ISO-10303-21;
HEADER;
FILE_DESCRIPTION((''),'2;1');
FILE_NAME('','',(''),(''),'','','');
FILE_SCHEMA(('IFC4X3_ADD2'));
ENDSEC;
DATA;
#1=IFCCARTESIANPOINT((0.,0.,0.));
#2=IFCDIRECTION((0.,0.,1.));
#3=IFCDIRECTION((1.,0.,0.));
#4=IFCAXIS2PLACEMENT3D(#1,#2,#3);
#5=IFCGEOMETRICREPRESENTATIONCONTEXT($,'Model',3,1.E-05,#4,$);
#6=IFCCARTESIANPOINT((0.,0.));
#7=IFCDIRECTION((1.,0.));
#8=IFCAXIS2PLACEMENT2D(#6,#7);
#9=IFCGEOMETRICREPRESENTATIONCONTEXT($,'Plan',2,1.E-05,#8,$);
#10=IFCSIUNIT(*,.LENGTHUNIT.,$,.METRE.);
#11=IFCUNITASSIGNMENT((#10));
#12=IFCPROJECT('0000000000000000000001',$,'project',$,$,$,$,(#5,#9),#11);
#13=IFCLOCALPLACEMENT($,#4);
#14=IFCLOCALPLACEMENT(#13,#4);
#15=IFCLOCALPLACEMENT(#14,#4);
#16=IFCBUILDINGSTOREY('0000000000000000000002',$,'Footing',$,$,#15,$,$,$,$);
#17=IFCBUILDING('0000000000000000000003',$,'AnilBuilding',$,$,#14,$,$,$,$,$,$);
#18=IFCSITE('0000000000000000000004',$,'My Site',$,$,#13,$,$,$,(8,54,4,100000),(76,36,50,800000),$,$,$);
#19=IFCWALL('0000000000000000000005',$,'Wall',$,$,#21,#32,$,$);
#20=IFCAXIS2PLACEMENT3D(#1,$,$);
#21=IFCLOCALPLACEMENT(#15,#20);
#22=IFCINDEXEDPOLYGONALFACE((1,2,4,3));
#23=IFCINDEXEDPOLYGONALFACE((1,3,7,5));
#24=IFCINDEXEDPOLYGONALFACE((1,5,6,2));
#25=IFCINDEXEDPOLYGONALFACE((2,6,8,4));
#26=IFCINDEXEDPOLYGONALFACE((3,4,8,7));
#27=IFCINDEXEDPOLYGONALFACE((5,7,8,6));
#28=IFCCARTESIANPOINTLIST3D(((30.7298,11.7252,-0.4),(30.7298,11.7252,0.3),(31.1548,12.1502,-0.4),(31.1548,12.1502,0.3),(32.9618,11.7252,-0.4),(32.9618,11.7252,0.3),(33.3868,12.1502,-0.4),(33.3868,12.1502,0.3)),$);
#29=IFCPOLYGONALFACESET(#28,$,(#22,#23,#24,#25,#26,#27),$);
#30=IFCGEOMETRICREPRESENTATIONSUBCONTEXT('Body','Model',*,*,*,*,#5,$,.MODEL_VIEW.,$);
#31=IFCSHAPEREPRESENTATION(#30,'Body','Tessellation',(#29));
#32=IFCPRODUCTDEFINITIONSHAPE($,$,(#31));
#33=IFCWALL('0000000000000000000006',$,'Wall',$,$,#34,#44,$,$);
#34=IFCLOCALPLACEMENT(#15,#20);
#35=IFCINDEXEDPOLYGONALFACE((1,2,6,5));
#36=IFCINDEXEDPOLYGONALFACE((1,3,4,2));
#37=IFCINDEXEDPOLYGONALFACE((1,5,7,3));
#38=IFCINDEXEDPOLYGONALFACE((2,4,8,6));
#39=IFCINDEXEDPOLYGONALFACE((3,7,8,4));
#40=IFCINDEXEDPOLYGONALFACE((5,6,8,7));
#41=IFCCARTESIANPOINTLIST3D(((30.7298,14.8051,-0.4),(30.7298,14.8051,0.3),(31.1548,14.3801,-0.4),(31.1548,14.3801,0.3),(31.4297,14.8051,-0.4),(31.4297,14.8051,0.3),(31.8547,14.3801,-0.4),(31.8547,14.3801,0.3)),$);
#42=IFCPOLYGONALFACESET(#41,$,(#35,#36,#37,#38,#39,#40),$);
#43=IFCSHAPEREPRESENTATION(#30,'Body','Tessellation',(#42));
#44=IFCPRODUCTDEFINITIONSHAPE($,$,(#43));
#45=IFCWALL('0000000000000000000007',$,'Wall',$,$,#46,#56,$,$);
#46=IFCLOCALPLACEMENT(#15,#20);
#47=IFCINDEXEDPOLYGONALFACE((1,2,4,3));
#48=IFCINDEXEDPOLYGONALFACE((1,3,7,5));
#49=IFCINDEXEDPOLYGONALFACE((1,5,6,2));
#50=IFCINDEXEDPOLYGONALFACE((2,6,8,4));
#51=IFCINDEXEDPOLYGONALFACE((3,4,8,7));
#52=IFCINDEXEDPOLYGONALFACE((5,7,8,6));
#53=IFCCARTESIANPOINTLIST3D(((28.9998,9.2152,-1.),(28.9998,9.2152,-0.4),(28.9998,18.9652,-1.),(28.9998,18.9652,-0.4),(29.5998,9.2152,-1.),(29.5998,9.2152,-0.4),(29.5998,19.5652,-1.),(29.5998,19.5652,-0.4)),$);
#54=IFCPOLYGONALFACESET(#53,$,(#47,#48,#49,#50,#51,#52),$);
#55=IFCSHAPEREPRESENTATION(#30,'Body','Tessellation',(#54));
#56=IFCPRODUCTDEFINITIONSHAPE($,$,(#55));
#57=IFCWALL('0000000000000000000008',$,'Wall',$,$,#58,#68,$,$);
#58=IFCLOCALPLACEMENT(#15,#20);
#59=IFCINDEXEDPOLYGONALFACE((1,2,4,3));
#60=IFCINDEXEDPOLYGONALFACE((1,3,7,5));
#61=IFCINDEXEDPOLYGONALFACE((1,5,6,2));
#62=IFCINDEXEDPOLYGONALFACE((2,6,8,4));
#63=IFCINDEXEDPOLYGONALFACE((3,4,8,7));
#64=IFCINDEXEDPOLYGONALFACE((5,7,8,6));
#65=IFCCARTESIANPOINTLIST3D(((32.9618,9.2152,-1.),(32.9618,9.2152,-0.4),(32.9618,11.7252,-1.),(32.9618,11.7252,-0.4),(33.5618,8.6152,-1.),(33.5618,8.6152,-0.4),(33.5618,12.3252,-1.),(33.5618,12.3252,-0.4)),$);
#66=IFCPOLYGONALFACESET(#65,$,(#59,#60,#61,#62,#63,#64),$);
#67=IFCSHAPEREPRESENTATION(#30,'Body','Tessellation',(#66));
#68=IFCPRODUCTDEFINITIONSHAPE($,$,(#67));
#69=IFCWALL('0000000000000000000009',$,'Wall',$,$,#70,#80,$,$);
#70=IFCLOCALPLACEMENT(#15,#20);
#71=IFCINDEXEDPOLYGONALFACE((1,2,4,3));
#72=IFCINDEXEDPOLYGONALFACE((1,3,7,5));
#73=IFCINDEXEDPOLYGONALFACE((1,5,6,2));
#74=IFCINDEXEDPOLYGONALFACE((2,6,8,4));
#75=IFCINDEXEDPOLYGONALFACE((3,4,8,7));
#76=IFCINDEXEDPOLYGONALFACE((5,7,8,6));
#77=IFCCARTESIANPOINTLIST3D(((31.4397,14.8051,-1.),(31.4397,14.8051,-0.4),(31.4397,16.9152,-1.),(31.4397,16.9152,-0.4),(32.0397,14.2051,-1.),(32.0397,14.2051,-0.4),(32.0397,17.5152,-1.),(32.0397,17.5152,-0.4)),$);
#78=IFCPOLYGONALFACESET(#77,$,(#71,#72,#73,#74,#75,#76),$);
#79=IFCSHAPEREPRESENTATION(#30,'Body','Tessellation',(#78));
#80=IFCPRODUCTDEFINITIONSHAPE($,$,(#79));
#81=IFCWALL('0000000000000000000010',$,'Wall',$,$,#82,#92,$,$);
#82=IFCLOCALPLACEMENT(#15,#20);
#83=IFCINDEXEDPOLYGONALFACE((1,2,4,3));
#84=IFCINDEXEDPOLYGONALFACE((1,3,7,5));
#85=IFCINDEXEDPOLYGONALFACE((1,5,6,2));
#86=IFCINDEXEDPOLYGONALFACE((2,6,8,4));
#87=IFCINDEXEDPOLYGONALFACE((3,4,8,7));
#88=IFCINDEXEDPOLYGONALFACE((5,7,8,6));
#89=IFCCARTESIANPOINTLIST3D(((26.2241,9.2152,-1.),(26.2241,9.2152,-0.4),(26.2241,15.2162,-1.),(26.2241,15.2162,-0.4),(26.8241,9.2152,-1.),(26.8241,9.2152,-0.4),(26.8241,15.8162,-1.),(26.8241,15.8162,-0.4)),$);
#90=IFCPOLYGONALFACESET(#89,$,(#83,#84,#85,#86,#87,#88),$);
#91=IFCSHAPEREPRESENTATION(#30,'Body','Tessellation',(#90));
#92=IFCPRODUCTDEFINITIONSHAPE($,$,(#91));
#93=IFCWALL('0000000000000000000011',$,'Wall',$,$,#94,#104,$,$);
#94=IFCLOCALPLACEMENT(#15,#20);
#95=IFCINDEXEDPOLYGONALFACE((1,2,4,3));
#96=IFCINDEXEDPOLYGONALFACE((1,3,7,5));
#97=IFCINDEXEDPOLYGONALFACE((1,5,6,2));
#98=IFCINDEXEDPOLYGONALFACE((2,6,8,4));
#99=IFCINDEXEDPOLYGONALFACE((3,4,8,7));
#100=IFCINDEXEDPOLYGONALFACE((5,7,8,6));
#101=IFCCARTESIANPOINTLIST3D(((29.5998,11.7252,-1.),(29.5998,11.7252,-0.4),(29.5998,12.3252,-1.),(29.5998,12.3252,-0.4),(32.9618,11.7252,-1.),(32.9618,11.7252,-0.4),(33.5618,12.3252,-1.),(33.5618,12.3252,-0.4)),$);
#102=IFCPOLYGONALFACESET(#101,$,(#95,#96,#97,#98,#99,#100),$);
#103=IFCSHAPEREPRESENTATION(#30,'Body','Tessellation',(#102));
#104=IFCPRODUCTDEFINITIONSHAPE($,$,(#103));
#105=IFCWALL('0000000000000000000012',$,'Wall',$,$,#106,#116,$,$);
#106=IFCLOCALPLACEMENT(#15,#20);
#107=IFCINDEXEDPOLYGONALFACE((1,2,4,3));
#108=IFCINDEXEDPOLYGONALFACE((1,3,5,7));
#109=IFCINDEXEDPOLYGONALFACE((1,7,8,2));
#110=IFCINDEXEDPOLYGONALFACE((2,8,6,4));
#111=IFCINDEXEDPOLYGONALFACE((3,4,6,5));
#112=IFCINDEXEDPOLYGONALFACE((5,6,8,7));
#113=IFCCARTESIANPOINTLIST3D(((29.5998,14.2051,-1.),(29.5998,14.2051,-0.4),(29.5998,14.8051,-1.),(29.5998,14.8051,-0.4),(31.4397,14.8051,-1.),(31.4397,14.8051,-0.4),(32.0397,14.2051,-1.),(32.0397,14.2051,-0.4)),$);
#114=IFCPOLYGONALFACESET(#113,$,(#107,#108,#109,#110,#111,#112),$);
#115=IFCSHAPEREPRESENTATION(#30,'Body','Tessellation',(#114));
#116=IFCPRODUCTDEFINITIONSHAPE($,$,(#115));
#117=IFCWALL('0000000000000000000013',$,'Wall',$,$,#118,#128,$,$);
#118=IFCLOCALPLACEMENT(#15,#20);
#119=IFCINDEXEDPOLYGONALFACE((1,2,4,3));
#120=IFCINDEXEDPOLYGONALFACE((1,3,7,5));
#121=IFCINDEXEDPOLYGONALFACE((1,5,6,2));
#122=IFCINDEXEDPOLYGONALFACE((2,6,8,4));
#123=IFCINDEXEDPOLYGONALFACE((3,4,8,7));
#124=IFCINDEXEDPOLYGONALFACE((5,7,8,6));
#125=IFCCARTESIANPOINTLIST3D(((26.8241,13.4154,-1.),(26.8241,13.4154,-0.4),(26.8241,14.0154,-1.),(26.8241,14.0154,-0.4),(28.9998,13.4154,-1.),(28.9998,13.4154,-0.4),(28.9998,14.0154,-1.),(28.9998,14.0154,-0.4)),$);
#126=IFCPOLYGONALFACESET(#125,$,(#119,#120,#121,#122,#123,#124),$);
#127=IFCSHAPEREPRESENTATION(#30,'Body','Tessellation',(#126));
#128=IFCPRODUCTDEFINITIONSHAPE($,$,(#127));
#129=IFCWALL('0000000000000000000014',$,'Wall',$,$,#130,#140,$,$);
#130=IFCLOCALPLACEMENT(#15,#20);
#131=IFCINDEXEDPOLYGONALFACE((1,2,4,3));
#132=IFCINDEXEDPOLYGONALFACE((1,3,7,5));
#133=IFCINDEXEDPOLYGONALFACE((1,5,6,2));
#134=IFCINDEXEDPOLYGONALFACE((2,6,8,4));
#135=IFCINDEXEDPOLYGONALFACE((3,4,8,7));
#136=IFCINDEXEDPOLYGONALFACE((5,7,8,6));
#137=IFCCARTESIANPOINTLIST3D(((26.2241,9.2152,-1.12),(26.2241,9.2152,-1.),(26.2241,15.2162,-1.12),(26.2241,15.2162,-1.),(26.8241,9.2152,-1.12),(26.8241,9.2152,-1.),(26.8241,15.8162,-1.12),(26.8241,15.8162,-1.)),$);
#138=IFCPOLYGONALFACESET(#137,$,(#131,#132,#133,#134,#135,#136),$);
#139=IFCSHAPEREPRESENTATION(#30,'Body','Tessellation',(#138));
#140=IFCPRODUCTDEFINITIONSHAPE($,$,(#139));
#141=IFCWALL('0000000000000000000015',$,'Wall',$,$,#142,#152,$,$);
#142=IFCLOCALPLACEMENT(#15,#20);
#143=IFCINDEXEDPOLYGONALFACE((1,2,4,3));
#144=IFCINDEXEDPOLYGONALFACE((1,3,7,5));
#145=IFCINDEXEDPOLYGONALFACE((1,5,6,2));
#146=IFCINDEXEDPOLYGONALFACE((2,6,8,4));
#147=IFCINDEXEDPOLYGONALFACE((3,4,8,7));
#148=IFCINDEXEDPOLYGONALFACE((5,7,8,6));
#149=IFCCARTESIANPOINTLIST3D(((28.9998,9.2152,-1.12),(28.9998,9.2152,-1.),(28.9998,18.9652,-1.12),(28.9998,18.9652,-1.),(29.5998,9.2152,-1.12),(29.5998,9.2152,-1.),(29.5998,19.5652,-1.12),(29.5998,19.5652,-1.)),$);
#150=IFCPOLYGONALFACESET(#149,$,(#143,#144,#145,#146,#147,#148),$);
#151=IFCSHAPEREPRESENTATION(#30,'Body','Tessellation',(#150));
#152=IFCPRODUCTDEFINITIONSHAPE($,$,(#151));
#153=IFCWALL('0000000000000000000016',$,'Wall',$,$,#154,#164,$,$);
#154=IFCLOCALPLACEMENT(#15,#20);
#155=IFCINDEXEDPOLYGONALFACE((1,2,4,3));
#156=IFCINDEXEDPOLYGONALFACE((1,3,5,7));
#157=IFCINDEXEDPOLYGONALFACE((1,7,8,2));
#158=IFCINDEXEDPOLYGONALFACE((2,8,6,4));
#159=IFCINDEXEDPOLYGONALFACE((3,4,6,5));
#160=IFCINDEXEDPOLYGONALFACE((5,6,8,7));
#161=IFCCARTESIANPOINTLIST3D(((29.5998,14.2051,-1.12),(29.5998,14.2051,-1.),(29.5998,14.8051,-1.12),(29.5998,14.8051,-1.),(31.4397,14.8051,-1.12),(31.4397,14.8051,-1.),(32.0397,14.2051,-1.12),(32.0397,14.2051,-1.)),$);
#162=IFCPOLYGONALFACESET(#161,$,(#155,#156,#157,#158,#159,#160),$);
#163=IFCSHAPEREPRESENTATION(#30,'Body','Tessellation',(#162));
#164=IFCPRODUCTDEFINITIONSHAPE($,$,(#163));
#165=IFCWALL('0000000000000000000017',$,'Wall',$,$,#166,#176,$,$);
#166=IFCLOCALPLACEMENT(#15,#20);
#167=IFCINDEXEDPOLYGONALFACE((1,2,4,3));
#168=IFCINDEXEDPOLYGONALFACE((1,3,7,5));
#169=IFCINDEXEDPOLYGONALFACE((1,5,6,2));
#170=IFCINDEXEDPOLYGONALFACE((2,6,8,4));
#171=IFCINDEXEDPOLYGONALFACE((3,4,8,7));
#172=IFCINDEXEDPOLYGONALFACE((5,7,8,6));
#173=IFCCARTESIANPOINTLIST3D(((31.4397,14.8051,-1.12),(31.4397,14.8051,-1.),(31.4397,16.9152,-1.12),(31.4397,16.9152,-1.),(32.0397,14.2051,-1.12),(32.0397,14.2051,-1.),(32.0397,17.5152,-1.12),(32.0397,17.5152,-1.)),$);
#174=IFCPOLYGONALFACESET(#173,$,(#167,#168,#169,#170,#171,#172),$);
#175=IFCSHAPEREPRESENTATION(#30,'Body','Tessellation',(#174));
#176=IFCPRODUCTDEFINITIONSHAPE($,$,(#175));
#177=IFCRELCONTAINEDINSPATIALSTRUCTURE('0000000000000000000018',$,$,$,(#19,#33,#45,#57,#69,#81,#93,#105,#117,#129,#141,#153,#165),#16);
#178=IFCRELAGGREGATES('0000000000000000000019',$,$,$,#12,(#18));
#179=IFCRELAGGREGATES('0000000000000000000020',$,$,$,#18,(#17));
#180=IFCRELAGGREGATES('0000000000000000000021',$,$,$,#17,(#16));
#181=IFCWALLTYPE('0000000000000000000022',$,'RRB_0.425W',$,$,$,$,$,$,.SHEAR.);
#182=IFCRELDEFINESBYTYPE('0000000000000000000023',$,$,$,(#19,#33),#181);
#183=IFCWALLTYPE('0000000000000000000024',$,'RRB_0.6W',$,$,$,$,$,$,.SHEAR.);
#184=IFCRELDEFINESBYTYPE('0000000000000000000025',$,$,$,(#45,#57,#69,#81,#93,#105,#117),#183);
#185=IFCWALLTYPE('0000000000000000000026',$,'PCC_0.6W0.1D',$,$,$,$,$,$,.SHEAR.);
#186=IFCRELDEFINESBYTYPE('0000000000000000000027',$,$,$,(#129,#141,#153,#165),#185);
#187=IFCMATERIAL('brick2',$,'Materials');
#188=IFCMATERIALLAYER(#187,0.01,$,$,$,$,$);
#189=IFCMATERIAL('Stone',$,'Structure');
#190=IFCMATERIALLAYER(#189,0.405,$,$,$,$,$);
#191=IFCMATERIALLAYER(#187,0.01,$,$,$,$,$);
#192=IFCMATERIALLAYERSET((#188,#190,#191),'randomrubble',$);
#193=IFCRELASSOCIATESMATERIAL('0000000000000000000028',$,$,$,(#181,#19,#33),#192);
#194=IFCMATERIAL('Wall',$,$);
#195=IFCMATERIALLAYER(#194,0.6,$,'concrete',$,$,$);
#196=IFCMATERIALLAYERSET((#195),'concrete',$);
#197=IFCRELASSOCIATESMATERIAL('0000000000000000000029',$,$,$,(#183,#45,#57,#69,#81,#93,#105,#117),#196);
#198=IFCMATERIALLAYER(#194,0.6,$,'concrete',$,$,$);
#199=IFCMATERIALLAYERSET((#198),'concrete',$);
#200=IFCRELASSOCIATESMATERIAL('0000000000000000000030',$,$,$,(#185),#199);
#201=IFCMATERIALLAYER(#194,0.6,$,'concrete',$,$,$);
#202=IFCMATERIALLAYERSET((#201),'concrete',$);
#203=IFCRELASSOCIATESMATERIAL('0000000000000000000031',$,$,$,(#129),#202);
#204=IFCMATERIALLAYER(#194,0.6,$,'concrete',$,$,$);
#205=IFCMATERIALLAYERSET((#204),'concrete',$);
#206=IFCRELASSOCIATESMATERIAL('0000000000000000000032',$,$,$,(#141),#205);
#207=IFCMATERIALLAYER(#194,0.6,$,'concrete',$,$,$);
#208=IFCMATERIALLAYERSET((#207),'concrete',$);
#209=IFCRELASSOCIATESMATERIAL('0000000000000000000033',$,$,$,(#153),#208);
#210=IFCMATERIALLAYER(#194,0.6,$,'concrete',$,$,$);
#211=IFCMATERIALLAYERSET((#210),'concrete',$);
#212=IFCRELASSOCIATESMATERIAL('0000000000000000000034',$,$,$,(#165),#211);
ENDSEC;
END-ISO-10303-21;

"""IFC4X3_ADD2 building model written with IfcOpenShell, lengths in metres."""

from ifc_helpers import new_model, si_unit, frame, origin_with_axes, origin_2d_with_axis, place, context, subcontext, project, spatial, line, indexed_curve, outline, extrude, material, layer, layer_set, layer_usage, type_object, element, save


model = new_model("IFC4X3_ADD2")

# Units and contexts
model_context = context("Model", 3, precision=1e-05, world=origin_with_axes())
plan_context = context("Plan", 2, precision=1e-05, world=origin_2d_with_axis())
body_context = subcontext(model_context, "Body", "Model", "MODEL_VIEW")
ifc_project = project(units=[si_unit("LENGTHUNIT", "METRE")], contexts=[model_context, plan_context])

# Site, building, storey
site_placement = place(None, origin_with_axes())
site = spatial("IfcSite", under=ifc_project, at=site_placement, Name="My Site", RefLatitude=(8, 54, 4, 100000), RefLongitude=(76, 36, 50, 800000))
building_placement = place(site_placement, origin_with_axes())
building = spatial("IfcBuilding", under=site, at=building_placement, Name="AnilBuilding")
storey_placement = place(building_placement, origin_with_axes())
storey = spatial("IfcBuildingStorey", under=building, at=storey_placement, Name="Footing")

# Shared definitions
ifc_material_1 = material(Name="Wall")
ifc_material_2 = material(Name="brick2", Category="Materials")
ifc_material_3 = material(Name="Stone", Category="Structure")

# Walls
ifc_layer_1 = layer(ifc_material_2, 0.01)
ifc_layer_2 = layer(ifc_material_3, 0.405)
ifc_layer_3 = layer(ifc_material_2, 0.01)
ifc_layer_set_1 = layer_set([ifc_layer_1, ifc_layer_2, ifc_layer_3], Name="randomrubble")
wall_type_1 = type_object("IfcWallType", Name="RRB_0.425W", PredefinedType="SHEAR", material=ifc_layer_set_1)
ifc_layer_usage_1 = layer_usage(ifc_layer_set_1, "AXIS2", "POSITIVE", 0.0)
wall_1_placement = place(storey_placement, frame((31.1548, 11.7252, -0.4), z_axis=(0.0, 0.0, 1.0), x_axis=(1.0, 0.0, 0.0)))
element("IfcWall", 1, at=wall_1_placement, inside=storey, type_object=wall_type_1, material=ifc_layer_usage_1, Name="Wall", context=body_context, shape_type="SweptSolid", body=[
    extrude(outline(indexed_curve([(-0.425, 0.0), (0.0, 0.425), (2.232, 0.425), (1.807, 0.0)], segments=[line(1, 2, 3, 4, 1)])), origin_with_axes(), (0.0, 0.0, 1.0), 0.7),
])
ifc_layer_usage_2 = layer_usage(ifc_layer_set_1, "AXIS2", "POSITIVE", 0.0)
wall_2_placement = place(storey_placement, frame((31.1548, 14.3801, -0.4), z_axis=(0.0, 0.0, 1.0), x_axis=(1.0, 0.0, 0.0)))
element("IfcWall", 2, at=wall_2_placement, inside=storey, type_object=wall_type_1, material=ifc_layer_usage_2, Name="Wall", context=body_context, shape_type="SweptSolid", body=[
    extrude(outline(indexed_curve([(0.0, 0.0), (-0.425, 0.425), (0.275, 0.425), (0.7, 0.0)], segments=[line(1, 2, 3, 4, 1)])), origin_with_axes(), (0.0, 0.0, 1.0), 0.7),
])
ifc_layer_4 = layer(ifc_material_1, 0.6, Name="concrete")
ifc_layer_set_2 = layer_set([ifc_layer_4], Name="concrete")
ifc_layer_usage_3 = layer_usage(ifc_layer_set_2, "AXIS2", "POSITIVE", 0.0)
wall_type_2 = type_object("IfcWallType", Name="RRB_0.6W", PredefinedType="SHEAR", material=ifc_layer_set_2)
wall_3_placement = place(storey_placement, frame((29.5998, 8.6152, -1.0), z_axis=(0.0, 0.0, 1.0), x_axis=(0.0, 1.0, 0.0)))
element("IfcWall", 3, at=wall_3_placement, inside=storey, type_object=wall_type_2, material=ifc_layer_usage_3, Name="Wall", context=body_context, shape_type="SweptSolid", body=[
    extrude(outline(indexed_curve([(0.6, 0.0), (0.6, 0.6), (10.35, 0.6), (10.95, 0.0)], segments=[line(1, 2, 3, 4, 1)])), origin_with_axes(), (0.0, 0.0, 1.0), 0.6),
])
ifc_layer_usage_4 = layer_usage(ifc_layer_set_2, "AXIS2", "POSITIVE", 0.0)
wall_4_placement = place(storey_placement, frame((33.5618, 8.6152, -1.0), z_axis=(0.0, 0.0, 1.0), x_axis=(0.0, 1.0, 0.0)))
element("IfcWall", 4, at=wall_4_placement, inside=storey, type_object=wall_type_2, material=ifc_layer_usage_4, Name="Wall", context=body_context, shape_type="SweptSolid", body=[
    extrude(outline(indexed_curve([(0.0, 0.0), (0.6, 0.6), (3.11, 0.6), (3.71, 0.0)], segments=[line(1, 2, 3, 4, 1)])), origin_with_axes(), (0.0, 0.0, 1.0), 0.6),
])
ifc_layer_usage_5 = layer_usage(ifc_layer_set_2, "AXIS2", "POSITIVE", 0.0)
wall_5_placement = place(storey_placement, frame((32.0397, 14.2051, -1.0), z_axis=(0.0, 0.0, 1.0), x_axis=(0.0, 1.0, 0.0)))
element("IfcWall", 5, at=wall_5_placement, inside=storey, type_object=wall_type_2, material=ifc_layer_usage_5, Name="Wall", context=body_context, shape_type="SweptSolid", body=[
    extrude(outline(indexed_curve([(0.0, 0.0), (0.6, 0.6), (2.71, 0.6), (3.31, 0.0)], segments=[line(1, 2, 3, 4, 1)])), origin_with_axes(), (0.0, 0.0, 1.0), 0.6),
])
ifc_layer_usage_6 = layer_usage(ifc_layer_set_2, "AXIS2", "POSITIVE", 0.0)
wall_6_placement = place(storey_placement, frame((26.8241, 8.6152, -1.0), z_axis=(0.0, 0.0, 1.0), x_axis=(0.0, 1.0, 0.0)))
element("IfcWall", 6, at=wall_6_placement, inside=storey, type_object=wall_type_2, material=ifc_layer_usage_6, Name="Wall", context=body_context, shape_type="SweptSolid", body=[
    extrude(outline(indexed_curve([(0.6, 0.0), (0.6, 0.6), (6.6011, 0.6), (7.2011, 0.0)], segments=[line(1, 2, 3, 4, 1)])), origin_with_axes(), (0.0, 0.0, 1.0), 0.6),
])
ifc_layer_usage_7 = layer_usage(ifc_layer_set_2, "AXIS2", "POSITIVE", 0.0)
wall_7_placement = place(storey_placement, frame((29.5998, 11.7252, -1.0), z_axis=(0.0, 0.0, 1.0), x_axis=(1.0, 0.0, 0.0)))
element("IfcWall", 7, at=wall_7_placement, inside=storey, type_object=wall_type_2, material=ifc_layer_usage_7, Name="Wall", context=body_context, shape_type="SweptSolid", body=[
    extrude(outline(indexed_curve([(0.0, 0.0), (0.0, 0.6), (3.962, 0.6), (3.362, 0.0)], segments=[line(1, 2, 3, 4, 1)])), origin_with_axes(), (0.0, 0.0, 1.0), 0.6),
])
ifc_layer_usage_8 = layer_usage(ifc_layer_set_2, "AXIS2", "POSITIVE", 0.0)
wall_8_placement = place(storey_placement, frame((29.5998, 14.2051, -1.0), z_axis=(0.0, 0.0, 1.0), x_axis=(1.0, 0.0, 0.0)))
element("IfcWall", 8, at=wall_8_placement, inside=storey, type_object=wall_type_2, material=ifc_layer_usage_8, Name="Wall", context=body_context, shape_type="SweptSolid", body=[
    extrude(outline(indexed_curve([(0.0, 0.0), (0.0, 0.6), (1.84, 0.6), (2.44, 0.0)], segments=[line(1, 2, 3, 4, 1)])), origin_with_axes(), (0.0, 0.0, 1.0), 0.6),
])
ifc_layer_usage_9 = layer_usage(ifc_layer_set_2, "AXIS2", "POSITIVE", 0.0)
wall_9_placement = place(storey_placement, frame((26.8241, 13.4154, -1.0), z_axis=(0.0, 0.0, 1.0), x_axis=(1.0, 0.0, 0.0)))
element("IfcWall", 9, at=wall_9_placement, inside=storey, type_object=wall_type_2, material=ifc_layer_usage_9, Name="Wall", context=body_context, shape_type="SweptSolid", body=[
    extrude(outline(indexed_curve([(0.0, 0.0), (0.0, 0.6), (2.1757, 0.6), (2.1757, 0.0)], segments=[line(1, 2, 3, 4, 1)])), origin_with_axes(), (0.0, 0.0, 1.0), 0.6),
])
ifc_layer_5 = layer(ifc_material_1, 0.6, Name="concrete")
ifc_layer_set_3 = layer_set([ifc_layer_5], Name="concrete")
ifc_layer_usage_10 = layer_usage(ifc_layer_set_3, "AXIS2", "POSITIVE", 0.0)
ifc_layer_6 = layer(ifc_material_1, 0.6, Name="concrete")
ifc_layer_set_4 = layer_set([ifc_layer_6], Name="concrete")
wall_type_3 = type_object("IfcWallType", Name="PCC_0.6W0.1D", PredefinedType="SHEAR", material=ifc_layer_set_4)
wall_10_placement = place(storey_placement, frame((26.8241, 8.6152, -1.12), z_axis=(0.0, 0.0, 1.0), x_axis=(0.0, 1.0, 0.0)))
element("IfcWall", 10, at=wall_10_placement, inside=storey, type_object=wall_type_3, material=ifc_layer_usage_10, Name="Wall", context=body_context, shape_type="SweptSolid", body=[
    extrude(outline(indexed_curve([(0.6, 0.0), (0.6, 0.6), (6.6011, 0.6), (7.2011, 0.0)], segments=[line(1, 2, 3, 4, 1)])), origin_with_axes(), (0.0, 0.0, 1.0), 0.12),
])
ifc_layer_7 = layer(ifc_material_1, 0.6, Name="concrete")
ifc_layer_set_5 = layer_set([ifc_layer_7], Name="concrete")
ifc_layer_usage_11 = layer_usage(ifc_layer_set_5, "AXIS2", "POSITIVE", 0.0)
wall_11_placement = place(storey_placement, frame((29.5998, 8.6152, -1.12), z_axis=(0.0, 0.0, 1.0), x_axis=(0.0, 1.0, 0.0)))
element("IfcWall", 11, at=wall_11_placement, inside=storey, type_object=wall_type_3, material=ifc_layer_usage_11, Name="Wall", context=body_context, shape_type="SweptSolid", body=[
    extrude(outline(indexed_curve([(0.6, 0.0), (0.6, 0.6), (10.35, 0.6), (10.95, 0.0)], segments=[line(1, 2, 3, 4, 1)])), origin_with_axes(), (0.0, 0.0, 1.0), 0.12),
])
ifc_layer_8 = layer(ifc_material_1, 0.6, Name="concrete")
ifc_layer_set_6 = layer_set([ifc_layer_8], Name="concrete")
ifc_layer_usage_12 = layer_usage(ifc_layer_set_6, "AXIS2", "POSITIVE", 0.0)
wall_12_placement = place(storey_placement, frame((29.5998, 14.2051, -1.12), z_axis=(0.0, 0.0, 1.0), x_axis=(1.0, 0.0, 0.0)))
element("IfcWall", 12, at=wall_12_placement, inside=storey, type_object=wall_type_3, material=ifc_layer_usage_12, Name="Wall", context=body_context, shape_type="SweptSolid", body=[
    extrude(outline(indexed_curve([(0.0, 0.0), (0.0, 0.6), (1.84, 0.6), (2.44, 0.0)], segments=[line(1, 2, 3, 4, 1)])), origin_with_axes(), (0.0, 0.0, 1.0), 0.12),
])
ifc_layer_9 = layer(ifc_material_1, 0.6, Name="concrete")
ifc_layer_set_7 = layer_set([ifc_layer_9], Name="concrete")
ifc_layer_usage_13 = layer_usage(ifc_layer_set_7, "AXIS2", "POSITIVE", 0.0)
wall_13_placement = place(storey_placement, frame((32.0397, 14.2051, -1.12), z_axis=(0.0, 0.0, 1.0), x_axis=(0.0, 1.0, 0.0)))
element("IfcWall", 13, at=wall_13_placement, inside=storey, type_object=wall_type_3, material=ifc_layer_usage_13, Name="Wall", context=body_context, shape_type="SweptSolid", body=[
    extrude(outline(indexed_curve([(0.0, 0.0), (0.6, 0.6), (2.71, 0.6), (3.31, 0.0)], segments=[line(1, 2, 3, 4, 1)])), origin_with_axes(), (0.0, 0.0, 1.0), 0.12),
])

save(model, "model.ifc")
